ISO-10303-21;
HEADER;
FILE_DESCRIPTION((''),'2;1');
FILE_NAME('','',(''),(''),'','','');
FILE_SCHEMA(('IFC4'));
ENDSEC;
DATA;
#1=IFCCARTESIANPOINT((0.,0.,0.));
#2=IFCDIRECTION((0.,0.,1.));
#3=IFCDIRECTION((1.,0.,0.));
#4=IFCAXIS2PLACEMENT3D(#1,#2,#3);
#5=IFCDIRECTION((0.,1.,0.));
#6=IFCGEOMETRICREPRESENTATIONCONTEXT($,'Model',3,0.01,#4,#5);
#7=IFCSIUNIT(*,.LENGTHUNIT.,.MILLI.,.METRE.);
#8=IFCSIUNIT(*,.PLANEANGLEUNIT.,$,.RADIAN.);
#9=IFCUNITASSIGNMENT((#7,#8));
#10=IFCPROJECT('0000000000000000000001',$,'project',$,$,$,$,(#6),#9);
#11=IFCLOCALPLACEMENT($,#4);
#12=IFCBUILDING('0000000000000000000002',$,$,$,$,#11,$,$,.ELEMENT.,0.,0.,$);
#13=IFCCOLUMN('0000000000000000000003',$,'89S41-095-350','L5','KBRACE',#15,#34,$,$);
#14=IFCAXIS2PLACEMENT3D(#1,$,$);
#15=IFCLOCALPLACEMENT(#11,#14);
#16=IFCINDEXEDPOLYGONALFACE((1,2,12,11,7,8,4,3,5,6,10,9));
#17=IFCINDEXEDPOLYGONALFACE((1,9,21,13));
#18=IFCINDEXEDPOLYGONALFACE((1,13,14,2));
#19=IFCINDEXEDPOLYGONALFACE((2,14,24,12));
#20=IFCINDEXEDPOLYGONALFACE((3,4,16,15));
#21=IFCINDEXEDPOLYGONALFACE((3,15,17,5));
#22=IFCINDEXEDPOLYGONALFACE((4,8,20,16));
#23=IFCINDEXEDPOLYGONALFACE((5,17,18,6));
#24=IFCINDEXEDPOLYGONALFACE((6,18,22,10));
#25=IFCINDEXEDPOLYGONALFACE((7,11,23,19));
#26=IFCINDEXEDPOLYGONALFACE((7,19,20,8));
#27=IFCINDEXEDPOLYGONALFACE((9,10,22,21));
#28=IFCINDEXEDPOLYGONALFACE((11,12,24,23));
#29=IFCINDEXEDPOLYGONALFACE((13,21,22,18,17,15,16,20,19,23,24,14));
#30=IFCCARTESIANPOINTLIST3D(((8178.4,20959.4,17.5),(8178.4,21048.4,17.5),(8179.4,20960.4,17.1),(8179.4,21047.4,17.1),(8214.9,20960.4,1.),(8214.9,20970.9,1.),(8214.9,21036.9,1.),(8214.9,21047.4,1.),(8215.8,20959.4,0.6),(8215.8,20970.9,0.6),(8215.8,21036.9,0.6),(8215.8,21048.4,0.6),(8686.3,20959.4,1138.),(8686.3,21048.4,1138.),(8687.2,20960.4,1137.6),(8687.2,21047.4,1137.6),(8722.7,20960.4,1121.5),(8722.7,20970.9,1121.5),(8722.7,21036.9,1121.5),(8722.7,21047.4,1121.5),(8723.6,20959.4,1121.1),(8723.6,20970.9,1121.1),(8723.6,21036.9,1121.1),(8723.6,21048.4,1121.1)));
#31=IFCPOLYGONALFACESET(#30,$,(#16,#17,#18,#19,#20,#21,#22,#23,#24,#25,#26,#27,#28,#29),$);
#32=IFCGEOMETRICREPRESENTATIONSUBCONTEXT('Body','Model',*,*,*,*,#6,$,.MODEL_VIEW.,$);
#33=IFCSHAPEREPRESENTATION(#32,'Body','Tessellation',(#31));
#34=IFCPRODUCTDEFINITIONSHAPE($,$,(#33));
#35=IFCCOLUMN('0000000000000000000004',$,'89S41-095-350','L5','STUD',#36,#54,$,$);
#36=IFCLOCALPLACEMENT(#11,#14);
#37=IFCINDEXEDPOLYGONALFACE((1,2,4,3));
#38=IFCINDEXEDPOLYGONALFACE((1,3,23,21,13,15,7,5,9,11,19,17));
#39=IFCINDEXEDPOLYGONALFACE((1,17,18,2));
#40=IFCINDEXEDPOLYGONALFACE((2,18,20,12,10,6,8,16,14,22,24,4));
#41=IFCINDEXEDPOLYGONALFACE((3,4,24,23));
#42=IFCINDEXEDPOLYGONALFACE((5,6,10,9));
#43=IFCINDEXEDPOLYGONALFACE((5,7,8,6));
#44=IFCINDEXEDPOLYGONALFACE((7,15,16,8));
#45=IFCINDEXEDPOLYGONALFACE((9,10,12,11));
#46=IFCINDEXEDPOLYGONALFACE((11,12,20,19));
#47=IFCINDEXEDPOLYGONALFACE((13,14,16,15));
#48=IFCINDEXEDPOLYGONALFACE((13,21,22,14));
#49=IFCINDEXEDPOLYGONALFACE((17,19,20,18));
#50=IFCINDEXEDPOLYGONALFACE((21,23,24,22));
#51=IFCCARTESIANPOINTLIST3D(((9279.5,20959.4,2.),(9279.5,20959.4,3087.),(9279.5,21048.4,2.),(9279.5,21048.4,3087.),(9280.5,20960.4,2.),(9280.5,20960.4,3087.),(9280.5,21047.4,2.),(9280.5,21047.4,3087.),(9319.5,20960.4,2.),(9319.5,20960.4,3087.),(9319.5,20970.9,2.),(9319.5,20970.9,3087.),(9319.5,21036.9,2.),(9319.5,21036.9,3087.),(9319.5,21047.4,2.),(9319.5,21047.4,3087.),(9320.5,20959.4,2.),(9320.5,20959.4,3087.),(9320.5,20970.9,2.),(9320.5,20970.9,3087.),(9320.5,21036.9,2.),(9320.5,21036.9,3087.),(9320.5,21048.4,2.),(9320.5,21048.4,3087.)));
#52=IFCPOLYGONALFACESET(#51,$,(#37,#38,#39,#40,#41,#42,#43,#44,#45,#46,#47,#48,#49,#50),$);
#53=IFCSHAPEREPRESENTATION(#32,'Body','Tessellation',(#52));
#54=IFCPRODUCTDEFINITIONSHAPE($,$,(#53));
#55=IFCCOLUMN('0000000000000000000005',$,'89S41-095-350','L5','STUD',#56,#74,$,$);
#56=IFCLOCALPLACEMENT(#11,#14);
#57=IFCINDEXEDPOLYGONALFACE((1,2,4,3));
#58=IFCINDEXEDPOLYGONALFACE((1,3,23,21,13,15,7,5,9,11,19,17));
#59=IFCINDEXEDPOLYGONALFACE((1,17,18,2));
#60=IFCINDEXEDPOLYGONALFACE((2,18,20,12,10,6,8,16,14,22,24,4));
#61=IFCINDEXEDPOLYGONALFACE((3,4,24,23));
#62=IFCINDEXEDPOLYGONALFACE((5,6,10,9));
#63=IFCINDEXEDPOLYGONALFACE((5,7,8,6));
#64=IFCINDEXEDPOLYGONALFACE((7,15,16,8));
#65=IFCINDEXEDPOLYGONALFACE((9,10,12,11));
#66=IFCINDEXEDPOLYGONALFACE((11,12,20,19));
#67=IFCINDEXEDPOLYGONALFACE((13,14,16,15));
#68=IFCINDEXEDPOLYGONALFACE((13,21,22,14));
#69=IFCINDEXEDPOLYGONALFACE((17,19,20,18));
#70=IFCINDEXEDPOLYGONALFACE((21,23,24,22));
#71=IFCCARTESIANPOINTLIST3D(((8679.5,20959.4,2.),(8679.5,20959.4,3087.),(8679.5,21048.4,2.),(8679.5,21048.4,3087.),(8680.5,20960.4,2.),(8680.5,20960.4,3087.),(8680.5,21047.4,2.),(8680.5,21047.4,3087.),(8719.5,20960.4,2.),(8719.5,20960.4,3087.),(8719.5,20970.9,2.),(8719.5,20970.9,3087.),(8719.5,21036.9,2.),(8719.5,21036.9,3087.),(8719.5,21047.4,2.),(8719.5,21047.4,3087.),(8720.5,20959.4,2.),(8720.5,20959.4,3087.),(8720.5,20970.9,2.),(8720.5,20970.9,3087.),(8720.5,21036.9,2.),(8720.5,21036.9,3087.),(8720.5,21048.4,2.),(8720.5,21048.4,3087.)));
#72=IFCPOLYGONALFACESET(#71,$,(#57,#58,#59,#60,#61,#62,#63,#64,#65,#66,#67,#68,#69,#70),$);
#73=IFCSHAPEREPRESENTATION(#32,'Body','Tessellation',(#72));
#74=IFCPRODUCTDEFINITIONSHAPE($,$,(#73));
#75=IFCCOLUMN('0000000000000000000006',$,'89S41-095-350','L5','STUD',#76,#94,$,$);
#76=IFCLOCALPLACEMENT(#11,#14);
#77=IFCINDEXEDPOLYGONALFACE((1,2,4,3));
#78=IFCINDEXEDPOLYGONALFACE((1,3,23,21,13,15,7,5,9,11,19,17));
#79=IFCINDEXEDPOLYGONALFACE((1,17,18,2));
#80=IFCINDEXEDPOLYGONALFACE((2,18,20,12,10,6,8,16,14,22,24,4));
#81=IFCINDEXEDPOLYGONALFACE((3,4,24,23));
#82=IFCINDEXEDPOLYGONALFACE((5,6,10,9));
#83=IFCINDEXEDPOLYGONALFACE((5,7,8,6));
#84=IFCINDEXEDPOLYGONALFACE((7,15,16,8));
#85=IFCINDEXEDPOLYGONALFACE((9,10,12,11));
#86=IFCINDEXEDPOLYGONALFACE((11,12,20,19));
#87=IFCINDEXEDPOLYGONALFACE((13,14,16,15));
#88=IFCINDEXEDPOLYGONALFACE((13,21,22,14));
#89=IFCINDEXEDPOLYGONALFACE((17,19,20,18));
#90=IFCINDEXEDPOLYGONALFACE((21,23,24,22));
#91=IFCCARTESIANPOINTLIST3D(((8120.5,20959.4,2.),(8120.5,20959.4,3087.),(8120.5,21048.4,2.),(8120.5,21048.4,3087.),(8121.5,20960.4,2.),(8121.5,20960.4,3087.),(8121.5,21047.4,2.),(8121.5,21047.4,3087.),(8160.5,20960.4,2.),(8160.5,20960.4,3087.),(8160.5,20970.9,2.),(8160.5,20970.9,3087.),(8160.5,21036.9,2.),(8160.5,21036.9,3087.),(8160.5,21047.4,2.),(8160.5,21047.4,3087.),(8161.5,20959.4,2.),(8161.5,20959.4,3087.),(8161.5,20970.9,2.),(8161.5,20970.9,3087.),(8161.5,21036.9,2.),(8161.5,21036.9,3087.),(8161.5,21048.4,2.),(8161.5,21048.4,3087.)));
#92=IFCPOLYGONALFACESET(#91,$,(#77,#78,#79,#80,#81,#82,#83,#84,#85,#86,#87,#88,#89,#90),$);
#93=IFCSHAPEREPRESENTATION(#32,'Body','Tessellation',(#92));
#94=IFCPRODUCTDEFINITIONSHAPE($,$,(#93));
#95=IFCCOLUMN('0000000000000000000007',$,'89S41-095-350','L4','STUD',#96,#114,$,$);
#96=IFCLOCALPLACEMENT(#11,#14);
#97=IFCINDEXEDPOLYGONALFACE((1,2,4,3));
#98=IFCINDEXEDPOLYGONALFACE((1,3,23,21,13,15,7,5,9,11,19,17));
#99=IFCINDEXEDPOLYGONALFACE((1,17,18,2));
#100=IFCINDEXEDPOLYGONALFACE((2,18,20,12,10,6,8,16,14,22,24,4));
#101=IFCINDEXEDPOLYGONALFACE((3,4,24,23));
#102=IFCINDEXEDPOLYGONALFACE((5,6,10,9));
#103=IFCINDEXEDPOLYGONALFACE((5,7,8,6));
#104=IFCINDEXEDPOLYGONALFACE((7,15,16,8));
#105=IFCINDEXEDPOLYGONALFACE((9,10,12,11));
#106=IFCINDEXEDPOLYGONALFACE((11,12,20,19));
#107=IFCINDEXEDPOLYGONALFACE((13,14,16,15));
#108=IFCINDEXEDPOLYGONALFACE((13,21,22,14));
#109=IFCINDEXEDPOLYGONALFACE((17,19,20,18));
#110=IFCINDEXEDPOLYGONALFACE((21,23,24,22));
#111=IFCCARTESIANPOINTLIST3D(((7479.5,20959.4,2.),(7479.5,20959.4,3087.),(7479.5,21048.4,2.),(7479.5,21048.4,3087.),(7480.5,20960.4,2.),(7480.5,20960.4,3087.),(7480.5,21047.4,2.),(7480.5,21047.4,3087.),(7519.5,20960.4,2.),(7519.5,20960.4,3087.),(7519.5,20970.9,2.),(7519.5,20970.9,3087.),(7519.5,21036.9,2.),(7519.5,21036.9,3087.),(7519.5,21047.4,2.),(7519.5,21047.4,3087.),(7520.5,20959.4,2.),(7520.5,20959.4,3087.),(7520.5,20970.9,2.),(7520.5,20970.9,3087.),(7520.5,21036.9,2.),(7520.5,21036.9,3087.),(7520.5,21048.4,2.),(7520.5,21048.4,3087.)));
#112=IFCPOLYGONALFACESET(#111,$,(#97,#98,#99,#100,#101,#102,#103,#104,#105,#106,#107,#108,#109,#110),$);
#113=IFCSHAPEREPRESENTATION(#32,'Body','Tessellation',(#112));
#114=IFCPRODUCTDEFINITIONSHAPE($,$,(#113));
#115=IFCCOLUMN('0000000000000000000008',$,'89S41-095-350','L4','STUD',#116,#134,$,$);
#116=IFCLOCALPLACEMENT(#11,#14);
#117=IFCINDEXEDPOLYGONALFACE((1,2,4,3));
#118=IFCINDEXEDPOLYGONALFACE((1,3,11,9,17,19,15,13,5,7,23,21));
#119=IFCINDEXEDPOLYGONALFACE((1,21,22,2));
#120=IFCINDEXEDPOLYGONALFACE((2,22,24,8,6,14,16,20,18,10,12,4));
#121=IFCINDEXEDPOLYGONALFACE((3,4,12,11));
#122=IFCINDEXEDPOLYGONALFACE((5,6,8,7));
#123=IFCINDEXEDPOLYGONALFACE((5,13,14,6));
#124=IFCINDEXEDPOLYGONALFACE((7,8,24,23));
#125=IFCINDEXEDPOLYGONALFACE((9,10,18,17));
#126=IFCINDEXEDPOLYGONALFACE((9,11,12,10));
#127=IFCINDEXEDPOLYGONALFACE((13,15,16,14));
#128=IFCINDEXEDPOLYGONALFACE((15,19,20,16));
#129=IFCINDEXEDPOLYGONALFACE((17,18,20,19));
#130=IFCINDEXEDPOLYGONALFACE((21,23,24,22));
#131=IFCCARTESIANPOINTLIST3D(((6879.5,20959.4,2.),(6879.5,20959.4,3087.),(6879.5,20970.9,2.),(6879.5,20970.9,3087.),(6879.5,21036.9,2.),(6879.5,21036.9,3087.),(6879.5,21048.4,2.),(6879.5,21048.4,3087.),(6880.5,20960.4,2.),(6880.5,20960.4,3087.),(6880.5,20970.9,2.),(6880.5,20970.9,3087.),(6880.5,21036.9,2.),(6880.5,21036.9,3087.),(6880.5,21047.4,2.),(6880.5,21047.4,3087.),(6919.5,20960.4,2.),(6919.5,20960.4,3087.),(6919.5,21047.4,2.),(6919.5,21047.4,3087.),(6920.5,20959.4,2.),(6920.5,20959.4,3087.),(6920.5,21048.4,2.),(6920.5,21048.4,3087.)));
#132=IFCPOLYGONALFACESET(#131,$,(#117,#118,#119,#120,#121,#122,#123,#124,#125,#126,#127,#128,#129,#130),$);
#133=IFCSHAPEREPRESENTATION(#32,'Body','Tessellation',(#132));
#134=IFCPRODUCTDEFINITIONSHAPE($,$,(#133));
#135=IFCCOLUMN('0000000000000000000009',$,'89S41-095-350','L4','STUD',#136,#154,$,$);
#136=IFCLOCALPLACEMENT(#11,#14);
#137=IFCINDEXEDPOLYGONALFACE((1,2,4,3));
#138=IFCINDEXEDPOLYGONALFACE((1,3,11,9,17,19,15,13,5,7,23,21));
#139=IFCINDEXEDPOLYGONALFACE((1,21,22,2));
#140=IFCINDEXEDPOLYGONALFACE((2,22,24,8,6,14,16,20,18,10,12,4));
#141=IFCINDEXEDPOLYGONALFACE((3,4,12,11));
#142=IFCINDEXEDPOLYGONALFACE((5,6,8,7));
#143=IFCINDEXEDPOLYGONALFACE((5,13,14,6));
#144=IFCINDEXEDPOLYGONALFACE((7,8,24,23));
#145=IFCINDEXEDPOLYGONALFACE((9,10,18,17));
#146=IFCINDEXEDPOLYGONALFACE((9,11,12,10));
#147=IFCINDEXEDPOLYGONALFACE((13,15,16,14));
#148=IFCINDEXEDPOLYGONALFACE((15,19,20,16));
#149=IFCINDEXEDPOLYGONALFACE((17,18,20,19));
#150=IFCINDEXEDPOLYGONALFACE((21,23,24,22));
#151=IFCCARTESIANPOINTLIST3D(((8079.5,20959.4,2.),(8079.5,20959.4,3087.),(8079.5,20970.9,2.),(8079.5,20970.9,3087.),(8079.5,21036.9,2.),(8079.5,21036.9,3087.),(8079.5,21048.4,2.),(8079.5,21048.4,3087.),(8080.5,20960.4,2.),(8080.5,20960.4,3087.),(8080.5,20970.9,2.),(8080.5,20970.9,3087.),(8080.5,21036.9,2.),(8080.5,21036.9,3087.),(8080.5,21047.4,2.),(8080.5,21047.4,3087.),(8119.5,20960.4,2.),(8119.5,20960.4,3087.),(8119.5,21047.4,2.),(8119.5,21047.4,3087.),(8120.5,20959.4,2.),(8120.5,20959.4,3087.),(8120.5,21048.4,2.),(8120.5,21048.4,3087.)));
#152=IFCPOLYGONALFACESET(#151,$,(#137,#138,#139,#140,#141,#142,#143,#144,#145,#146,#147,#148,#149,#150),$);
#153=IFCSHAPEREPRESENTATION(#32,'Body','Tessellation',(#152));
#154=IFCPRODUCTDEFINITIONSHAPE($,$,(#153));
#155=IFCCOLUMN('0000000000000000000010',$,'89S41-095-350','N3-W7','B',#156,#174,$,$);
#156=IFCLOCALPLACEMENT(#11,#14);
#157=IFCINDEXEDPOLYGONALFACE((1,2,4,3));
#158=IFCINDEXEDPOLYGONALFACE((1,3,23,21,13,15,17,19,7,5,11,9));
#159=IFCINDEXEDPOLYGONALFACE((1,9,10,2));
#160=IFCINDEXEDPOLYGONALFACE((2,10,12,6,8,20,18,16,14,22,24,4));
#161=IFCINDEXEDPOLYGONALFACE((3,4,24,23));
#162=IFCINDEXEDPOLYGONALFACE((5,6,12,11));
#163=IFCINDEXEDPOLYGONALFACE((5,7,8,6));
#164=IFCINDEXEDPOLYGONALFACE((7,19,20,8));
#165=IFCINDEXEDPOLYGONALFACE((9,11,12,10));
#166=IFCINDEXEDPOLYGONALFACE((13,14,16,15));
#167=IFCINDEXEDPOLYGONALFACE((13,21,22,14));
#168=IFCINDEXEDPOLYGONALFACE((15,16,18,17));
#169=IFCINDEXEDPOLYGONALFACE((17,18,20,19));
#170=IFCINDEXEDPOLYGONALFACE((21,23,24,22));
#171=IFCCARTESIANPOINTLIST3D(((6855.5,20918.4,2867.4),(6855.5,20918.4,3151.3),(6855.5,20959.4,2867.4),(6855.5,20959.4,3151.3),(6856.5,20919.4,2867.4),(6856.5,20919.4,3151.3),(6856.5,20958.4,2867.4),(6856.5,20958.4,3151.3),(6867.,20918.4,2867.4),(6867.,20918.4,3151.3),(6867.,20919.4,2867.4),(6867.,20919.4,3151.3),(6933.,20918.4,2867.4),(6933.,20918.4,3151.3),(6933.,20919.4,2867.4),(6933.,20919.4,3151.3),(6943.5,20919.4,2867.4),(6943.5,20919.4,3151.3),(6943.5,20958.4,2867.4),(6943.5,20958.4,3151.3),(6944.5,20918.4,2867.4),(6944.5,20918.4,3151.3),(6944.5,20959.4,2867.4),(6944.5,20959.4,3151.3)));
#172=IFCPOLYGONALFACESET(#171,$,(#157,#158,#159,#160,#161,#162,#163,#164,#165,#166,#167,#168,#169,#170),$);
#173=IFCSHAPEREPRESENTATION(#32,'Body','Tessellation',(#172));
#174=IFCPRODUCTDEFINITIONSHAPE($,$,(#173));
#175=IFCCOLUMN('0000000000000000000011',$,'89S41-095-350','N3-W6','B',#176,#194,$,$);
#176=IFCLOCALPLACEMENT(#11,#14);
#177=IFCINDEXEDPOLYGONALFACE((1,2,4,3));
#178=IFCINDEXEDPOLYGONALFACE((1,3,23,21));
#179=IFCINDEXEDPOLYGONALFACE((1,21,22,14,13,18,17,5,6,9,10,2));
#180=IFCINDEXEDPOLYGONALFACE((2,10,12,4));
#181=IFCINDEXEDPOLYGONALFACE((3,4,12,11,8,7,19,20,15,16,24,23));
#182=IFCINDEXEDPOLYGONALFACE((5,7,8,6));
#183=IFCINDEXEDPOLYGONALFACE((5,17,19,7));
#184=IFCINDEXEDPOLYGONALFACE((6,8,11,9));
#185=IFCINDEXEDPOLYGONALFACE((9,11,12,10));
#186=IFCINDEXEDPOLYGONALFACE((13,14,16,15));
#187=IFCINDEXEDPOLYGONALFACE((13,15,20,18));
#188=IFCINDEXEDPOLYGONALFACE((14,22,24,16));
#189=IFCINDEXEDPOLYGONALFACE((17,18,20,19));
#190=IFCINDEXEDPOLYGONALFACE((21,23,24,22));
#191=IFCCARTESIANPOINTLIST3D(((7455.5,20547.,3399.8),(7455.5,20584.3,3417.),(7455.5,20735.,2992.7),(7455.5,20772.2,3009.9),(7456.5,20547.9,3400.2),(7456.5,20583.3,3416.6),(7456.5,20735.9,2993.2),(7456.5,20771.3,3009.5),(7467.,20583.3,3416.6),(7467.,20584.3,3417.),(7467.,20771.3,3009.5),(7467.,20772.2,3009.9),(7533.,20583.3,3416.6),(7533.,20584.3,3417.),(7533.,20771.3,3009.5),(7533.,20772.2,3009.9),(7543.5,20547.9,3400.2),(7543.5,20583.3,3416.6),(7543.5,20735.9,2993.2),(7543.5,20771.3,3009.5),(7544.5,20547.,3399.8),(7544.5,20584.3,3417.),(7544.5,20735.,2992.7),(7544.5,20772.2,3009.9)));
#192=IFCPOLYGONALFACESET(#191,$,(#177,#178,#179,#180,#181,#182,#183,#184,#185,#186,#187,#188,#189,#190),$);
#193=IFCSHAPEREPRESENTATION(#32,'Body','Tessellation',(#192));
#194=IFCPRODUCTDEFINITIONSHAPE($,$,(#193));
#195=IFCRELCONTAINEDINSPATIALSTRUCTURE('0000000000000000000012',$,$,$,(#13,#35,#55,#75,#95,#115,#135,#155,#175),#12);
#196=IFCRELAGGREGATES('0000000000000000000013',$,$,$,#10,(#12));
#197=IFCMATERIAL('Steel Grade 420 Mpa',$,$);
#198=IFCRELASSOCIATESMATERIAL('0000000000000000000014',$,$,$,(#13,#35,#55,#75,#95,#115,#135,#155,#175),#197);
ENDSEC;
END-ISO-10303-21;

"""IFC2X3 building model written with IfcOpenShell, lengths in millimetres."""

from ifc_helpers import new_model, si_unit, direction, frame, origin, origin_with_axes, origin_2d_with_axis, place, context, subcontext, project, spatial, c_section, extrude, source, transform, mapped, material, element, save


model = new_model("IFC2X3")

# Units and contexts
model_context = context("Model", 3, precision=0.01, world=origin_with_axes(), true_north=direction((0.0, 1.0, 0.0)))
body_context = subcontext(model_context, "Body", "Model", "MODEL_VIEW")
ifc_project = project(units=[si_unit("LENGTHUNIT", "METRE", prefix="MILLI"), si_unit("PLANEANGLEUNIT", "RADIAN")], contexts=[model_context])

# Building
building_placement = place(None, origin_with_axes())
building = spatial("IfcBuilding", under=ifc_project, at=building_placement, CompositionType="ELEMENT", ElevationOfRefHeight=0.0, ElevationOfTerrain=0.0)

# Columns
ifc_material = material(Name="Steel Grade 420 Mpa")
shared_shape_1 = source(origin(), body_context, "Body", "SweptSolid", [
    extrude(c_section(Depth=89.0, Width=41.0, WallThickness=1.0, Girth=11.5, at=origin_2d_with_axis()), origin_with_axes(), (0.0, 0.0, 1.0), 1230.2),
])
column_1_placement = place(None, frame((8197.1, 21003.9, 9.1), z_axis=(0.412828, 0.0, 0.910809), x_axis=(0.910809, 0.0, -0.412828)))
element("IfcColumn", 1, at=column_1_placement, inside=building, material=ifc_material, Name="89S41-095-350", Description="L5", ObjectType="KBRACE", context=body_context, shape_type="MappedRepresentation", body=[
    mapped(shared_shape_1, transform((0.0, 0.0, 0.0), scale=1.0)),
])
shared_shape_2 = source(origin(), body_context, "Body", "SweptSolid", [
    extrude(c_section(Depth=89.0, Width=41.0, WallThickness=1.0, Girth=11.5, at=origin_2d_with_axis()), origin_with_axes(), (0.0, 0.0, 1.0), 3085.0),
])
column_2_placement = place(None, frame((9300.0, 21003.9, 2.0), z_axis=(0.0, 0.0, 1.0), x_axis=(1.0, 0.0, 0.0)))
element("IfcColumn", 2, at=column_2_placement, inside=building, material=ifc_material, Name="89S41-095-350", Description="L5", ObjectType="STUD", context=body_context, shape_type="MappedRepresentation", body=[
    mapped(shared_shape_2, transform((0.0, 0.0, 0.0), scale=1.0)),
])
shared_shape_3 = source(origin(), body_context, "Body", "SweptSolid", [
    extrude(c_section(Depth=89.0, Width=41.0, WallThickness=1.0, Girth=11.5, at=origin_2d_with_axis()), origin_with_axes(), (0.0, 0.0, 1.0), 3085.0),
])
column_3_placement = place(None, frame((8700.0, 21003.9, 2.0), z_axis=(0.0, 0.0, 1.0), x_axis=(1.0, 0.0, 0.0)))
element("IfcColumn", 3, at=column_3_placement, inside=building, material=ifc_material, Name="89S41-095-350", Description="L5", ObjectType="STUD", context=body_context, shape_type="MappedRepresentation", body=[
    mapped(shared_shape_3, transform((0.0, 0.0, 0.0), scale=1.0)),
])
shared_shape_4 = source(origin(), body_context, "Body", "SweptSolid", [
    extrude(c_section(Depth=89.0, Width=41.0, WallThickness=1.0, Girth=11.5, at=origin_2d_with_axis()), origin_with_axes(), (0.0, 0.0, 1.0), 3085.0),
])
column_4_placement = place(None, frame((8141.0, 21003.9, 2.0), z_axis=(0.0, 0.0, 1.0), x_axis=(1.0, 0.0, 0.0)))
element("IfcColumn", 4, at=column_4_placement, inside=building, material=ifc_material, Name="89S41-095-350", Description="L5", ObjectType="STUD", context=body_context, shape_type="MappedRepresentation", body=[
    mapped(shared_shape_4, transform((0.0, 0.0, 0.0), scale=1.0)),
])
shared_shape_5 = source(origin(), body_context, "Body", "SweptSolid", [
    extrude(c_section(Depth=89.0, Width=41.0, WallThickness=1.0, Girth=11.5, at=origin_2d_with_axis()), origin_with_axes(), (0.0, 0.0, 1.0), 3085.0),
])
column_5_placement = place(None, frame((7500.0, 21003.9, 2.0), z_axis=(0.0, 0.0, 1.0), x_axis=(1.0, 0.0, 0.0)))
element("IfcColumn", 5, at=column_5_placement, inside=building, material=ifc_material, Name="89S41-095-350", Description="L4", ObjectType="STUD", context=body_context, shape_type="MappedRepresentation", body=[
    mapped(shared_shape_5, transform((0.0, 0.0, 0.0), scale=1.0)),
])
shared_shape_6 = source(origin(), body_context, "Body", "SweptSolid", [
    extrude(c_section(Depth=89.0, Width=41.0, WallThickness=1.0, Girth=11.5, at=origin_2d_with_axis()), origin_with_axes(), (0.0, 0.0, 1.0), 3085.0),
])
column_6_placement = place(None, frame((6900.0, 21003.9, 2.0), z_axis=(0.0, 0.0, 1.0), x_axis=(-1.0, 0.0, 0.0)))
element("IfcColumn", 6, at=column_6_placement, inside=building, material=ifc_material, Name="89S41-095-350", Description="L4", ObjectType="STUD", context=body_context, shape_type="MappedRepresentation", body=[
    mapped(shared_shape_6, transform((0.0, 0.0, 0.0), scale=1.0)),
])
shared_shape_7 = source(origin(), body_context, "Body", "SweptSolid", [
    extrude(c_section(Depth=89.0, Width=41.0, WallThickness=1.0, Girth=11.5, at=origin_2d_with_axis()), origin_with_axes(), (0.0, 0.0, 1.0), 3085.0),
])
column_7_placement = place(None, frame((8100.0, 21003.9, 2.0), z_axis=(0.0, 0.0, 1.0), x_axis=(-1.0, 0.0, 0.0)))
element("IfcColumn", 7, at=column_7_placement, inside=building, material=ifc_material, Name="89S41-095-350", Description="L4", ObjectType="STUD", context=body_context, shape_type="MappedRepresentation", body=[
    mapped(shared_shape_7, transform((0.0, 0.0, 0.0), scale=1.0)),
])
shared_shape_8 = source(origin(), body_context, "Body", "SweptSolid", [
    extrude(c_section(Depth=89.0, Width=41.0, WallThickness=1.0, Girth=11.5, at=origin_2d_with_axis()), origin_with_axes(), (0.0, 0.0, 1.0), 283.9),
])
column_8_placement = place(None, frame((6900.0, 20938.9, 3151.3), z_axis=(0.0, 0.0, -1.0), x_axis=(0.0, -1.0, 0.0)))
element("IfcColumn", 8, at=column_8_placement, inside=building, material=ifc_material, Name="89S41-095-350", Description="N3-W7", ObjectType="B", context=body_context, shape_type="MappedRepresentation", body=[
    mapped(shared_shape_8, transform((0.0, 0.0, 0.0), scale=1.0)),
])
shared_shape_9 = source(origin(), body_context, "Body", "SweptSolid", [
    extrude(c_section(Depth=89.0, Width=41.0, WallThickness=1.0, Girth=11.5, at=origin_2d_with_axis()), origin_with_axes(), (0.0, 0.0, 1.0), 448.4),
])
column_9_placement = place(None, frame((7500.0, 20753.6, 3001.3), z_axis=(0.0, -0.419234, 0.907878), x_axis=(0.0, 0.907878, 0.419234)))
element("IfcColumn", 9, at=column_9_placement, inside=building, material=ifc_material, Name="89S41-095-350", Description="N3-W6", ObjectType="B", context=body_context, shape_type="MappedRepresentation", body=[
    mapped(shared_shape_9, transform((0.0, 0.0, 0.0), scale=1.0)),
])

save(model, "model.ifc")
